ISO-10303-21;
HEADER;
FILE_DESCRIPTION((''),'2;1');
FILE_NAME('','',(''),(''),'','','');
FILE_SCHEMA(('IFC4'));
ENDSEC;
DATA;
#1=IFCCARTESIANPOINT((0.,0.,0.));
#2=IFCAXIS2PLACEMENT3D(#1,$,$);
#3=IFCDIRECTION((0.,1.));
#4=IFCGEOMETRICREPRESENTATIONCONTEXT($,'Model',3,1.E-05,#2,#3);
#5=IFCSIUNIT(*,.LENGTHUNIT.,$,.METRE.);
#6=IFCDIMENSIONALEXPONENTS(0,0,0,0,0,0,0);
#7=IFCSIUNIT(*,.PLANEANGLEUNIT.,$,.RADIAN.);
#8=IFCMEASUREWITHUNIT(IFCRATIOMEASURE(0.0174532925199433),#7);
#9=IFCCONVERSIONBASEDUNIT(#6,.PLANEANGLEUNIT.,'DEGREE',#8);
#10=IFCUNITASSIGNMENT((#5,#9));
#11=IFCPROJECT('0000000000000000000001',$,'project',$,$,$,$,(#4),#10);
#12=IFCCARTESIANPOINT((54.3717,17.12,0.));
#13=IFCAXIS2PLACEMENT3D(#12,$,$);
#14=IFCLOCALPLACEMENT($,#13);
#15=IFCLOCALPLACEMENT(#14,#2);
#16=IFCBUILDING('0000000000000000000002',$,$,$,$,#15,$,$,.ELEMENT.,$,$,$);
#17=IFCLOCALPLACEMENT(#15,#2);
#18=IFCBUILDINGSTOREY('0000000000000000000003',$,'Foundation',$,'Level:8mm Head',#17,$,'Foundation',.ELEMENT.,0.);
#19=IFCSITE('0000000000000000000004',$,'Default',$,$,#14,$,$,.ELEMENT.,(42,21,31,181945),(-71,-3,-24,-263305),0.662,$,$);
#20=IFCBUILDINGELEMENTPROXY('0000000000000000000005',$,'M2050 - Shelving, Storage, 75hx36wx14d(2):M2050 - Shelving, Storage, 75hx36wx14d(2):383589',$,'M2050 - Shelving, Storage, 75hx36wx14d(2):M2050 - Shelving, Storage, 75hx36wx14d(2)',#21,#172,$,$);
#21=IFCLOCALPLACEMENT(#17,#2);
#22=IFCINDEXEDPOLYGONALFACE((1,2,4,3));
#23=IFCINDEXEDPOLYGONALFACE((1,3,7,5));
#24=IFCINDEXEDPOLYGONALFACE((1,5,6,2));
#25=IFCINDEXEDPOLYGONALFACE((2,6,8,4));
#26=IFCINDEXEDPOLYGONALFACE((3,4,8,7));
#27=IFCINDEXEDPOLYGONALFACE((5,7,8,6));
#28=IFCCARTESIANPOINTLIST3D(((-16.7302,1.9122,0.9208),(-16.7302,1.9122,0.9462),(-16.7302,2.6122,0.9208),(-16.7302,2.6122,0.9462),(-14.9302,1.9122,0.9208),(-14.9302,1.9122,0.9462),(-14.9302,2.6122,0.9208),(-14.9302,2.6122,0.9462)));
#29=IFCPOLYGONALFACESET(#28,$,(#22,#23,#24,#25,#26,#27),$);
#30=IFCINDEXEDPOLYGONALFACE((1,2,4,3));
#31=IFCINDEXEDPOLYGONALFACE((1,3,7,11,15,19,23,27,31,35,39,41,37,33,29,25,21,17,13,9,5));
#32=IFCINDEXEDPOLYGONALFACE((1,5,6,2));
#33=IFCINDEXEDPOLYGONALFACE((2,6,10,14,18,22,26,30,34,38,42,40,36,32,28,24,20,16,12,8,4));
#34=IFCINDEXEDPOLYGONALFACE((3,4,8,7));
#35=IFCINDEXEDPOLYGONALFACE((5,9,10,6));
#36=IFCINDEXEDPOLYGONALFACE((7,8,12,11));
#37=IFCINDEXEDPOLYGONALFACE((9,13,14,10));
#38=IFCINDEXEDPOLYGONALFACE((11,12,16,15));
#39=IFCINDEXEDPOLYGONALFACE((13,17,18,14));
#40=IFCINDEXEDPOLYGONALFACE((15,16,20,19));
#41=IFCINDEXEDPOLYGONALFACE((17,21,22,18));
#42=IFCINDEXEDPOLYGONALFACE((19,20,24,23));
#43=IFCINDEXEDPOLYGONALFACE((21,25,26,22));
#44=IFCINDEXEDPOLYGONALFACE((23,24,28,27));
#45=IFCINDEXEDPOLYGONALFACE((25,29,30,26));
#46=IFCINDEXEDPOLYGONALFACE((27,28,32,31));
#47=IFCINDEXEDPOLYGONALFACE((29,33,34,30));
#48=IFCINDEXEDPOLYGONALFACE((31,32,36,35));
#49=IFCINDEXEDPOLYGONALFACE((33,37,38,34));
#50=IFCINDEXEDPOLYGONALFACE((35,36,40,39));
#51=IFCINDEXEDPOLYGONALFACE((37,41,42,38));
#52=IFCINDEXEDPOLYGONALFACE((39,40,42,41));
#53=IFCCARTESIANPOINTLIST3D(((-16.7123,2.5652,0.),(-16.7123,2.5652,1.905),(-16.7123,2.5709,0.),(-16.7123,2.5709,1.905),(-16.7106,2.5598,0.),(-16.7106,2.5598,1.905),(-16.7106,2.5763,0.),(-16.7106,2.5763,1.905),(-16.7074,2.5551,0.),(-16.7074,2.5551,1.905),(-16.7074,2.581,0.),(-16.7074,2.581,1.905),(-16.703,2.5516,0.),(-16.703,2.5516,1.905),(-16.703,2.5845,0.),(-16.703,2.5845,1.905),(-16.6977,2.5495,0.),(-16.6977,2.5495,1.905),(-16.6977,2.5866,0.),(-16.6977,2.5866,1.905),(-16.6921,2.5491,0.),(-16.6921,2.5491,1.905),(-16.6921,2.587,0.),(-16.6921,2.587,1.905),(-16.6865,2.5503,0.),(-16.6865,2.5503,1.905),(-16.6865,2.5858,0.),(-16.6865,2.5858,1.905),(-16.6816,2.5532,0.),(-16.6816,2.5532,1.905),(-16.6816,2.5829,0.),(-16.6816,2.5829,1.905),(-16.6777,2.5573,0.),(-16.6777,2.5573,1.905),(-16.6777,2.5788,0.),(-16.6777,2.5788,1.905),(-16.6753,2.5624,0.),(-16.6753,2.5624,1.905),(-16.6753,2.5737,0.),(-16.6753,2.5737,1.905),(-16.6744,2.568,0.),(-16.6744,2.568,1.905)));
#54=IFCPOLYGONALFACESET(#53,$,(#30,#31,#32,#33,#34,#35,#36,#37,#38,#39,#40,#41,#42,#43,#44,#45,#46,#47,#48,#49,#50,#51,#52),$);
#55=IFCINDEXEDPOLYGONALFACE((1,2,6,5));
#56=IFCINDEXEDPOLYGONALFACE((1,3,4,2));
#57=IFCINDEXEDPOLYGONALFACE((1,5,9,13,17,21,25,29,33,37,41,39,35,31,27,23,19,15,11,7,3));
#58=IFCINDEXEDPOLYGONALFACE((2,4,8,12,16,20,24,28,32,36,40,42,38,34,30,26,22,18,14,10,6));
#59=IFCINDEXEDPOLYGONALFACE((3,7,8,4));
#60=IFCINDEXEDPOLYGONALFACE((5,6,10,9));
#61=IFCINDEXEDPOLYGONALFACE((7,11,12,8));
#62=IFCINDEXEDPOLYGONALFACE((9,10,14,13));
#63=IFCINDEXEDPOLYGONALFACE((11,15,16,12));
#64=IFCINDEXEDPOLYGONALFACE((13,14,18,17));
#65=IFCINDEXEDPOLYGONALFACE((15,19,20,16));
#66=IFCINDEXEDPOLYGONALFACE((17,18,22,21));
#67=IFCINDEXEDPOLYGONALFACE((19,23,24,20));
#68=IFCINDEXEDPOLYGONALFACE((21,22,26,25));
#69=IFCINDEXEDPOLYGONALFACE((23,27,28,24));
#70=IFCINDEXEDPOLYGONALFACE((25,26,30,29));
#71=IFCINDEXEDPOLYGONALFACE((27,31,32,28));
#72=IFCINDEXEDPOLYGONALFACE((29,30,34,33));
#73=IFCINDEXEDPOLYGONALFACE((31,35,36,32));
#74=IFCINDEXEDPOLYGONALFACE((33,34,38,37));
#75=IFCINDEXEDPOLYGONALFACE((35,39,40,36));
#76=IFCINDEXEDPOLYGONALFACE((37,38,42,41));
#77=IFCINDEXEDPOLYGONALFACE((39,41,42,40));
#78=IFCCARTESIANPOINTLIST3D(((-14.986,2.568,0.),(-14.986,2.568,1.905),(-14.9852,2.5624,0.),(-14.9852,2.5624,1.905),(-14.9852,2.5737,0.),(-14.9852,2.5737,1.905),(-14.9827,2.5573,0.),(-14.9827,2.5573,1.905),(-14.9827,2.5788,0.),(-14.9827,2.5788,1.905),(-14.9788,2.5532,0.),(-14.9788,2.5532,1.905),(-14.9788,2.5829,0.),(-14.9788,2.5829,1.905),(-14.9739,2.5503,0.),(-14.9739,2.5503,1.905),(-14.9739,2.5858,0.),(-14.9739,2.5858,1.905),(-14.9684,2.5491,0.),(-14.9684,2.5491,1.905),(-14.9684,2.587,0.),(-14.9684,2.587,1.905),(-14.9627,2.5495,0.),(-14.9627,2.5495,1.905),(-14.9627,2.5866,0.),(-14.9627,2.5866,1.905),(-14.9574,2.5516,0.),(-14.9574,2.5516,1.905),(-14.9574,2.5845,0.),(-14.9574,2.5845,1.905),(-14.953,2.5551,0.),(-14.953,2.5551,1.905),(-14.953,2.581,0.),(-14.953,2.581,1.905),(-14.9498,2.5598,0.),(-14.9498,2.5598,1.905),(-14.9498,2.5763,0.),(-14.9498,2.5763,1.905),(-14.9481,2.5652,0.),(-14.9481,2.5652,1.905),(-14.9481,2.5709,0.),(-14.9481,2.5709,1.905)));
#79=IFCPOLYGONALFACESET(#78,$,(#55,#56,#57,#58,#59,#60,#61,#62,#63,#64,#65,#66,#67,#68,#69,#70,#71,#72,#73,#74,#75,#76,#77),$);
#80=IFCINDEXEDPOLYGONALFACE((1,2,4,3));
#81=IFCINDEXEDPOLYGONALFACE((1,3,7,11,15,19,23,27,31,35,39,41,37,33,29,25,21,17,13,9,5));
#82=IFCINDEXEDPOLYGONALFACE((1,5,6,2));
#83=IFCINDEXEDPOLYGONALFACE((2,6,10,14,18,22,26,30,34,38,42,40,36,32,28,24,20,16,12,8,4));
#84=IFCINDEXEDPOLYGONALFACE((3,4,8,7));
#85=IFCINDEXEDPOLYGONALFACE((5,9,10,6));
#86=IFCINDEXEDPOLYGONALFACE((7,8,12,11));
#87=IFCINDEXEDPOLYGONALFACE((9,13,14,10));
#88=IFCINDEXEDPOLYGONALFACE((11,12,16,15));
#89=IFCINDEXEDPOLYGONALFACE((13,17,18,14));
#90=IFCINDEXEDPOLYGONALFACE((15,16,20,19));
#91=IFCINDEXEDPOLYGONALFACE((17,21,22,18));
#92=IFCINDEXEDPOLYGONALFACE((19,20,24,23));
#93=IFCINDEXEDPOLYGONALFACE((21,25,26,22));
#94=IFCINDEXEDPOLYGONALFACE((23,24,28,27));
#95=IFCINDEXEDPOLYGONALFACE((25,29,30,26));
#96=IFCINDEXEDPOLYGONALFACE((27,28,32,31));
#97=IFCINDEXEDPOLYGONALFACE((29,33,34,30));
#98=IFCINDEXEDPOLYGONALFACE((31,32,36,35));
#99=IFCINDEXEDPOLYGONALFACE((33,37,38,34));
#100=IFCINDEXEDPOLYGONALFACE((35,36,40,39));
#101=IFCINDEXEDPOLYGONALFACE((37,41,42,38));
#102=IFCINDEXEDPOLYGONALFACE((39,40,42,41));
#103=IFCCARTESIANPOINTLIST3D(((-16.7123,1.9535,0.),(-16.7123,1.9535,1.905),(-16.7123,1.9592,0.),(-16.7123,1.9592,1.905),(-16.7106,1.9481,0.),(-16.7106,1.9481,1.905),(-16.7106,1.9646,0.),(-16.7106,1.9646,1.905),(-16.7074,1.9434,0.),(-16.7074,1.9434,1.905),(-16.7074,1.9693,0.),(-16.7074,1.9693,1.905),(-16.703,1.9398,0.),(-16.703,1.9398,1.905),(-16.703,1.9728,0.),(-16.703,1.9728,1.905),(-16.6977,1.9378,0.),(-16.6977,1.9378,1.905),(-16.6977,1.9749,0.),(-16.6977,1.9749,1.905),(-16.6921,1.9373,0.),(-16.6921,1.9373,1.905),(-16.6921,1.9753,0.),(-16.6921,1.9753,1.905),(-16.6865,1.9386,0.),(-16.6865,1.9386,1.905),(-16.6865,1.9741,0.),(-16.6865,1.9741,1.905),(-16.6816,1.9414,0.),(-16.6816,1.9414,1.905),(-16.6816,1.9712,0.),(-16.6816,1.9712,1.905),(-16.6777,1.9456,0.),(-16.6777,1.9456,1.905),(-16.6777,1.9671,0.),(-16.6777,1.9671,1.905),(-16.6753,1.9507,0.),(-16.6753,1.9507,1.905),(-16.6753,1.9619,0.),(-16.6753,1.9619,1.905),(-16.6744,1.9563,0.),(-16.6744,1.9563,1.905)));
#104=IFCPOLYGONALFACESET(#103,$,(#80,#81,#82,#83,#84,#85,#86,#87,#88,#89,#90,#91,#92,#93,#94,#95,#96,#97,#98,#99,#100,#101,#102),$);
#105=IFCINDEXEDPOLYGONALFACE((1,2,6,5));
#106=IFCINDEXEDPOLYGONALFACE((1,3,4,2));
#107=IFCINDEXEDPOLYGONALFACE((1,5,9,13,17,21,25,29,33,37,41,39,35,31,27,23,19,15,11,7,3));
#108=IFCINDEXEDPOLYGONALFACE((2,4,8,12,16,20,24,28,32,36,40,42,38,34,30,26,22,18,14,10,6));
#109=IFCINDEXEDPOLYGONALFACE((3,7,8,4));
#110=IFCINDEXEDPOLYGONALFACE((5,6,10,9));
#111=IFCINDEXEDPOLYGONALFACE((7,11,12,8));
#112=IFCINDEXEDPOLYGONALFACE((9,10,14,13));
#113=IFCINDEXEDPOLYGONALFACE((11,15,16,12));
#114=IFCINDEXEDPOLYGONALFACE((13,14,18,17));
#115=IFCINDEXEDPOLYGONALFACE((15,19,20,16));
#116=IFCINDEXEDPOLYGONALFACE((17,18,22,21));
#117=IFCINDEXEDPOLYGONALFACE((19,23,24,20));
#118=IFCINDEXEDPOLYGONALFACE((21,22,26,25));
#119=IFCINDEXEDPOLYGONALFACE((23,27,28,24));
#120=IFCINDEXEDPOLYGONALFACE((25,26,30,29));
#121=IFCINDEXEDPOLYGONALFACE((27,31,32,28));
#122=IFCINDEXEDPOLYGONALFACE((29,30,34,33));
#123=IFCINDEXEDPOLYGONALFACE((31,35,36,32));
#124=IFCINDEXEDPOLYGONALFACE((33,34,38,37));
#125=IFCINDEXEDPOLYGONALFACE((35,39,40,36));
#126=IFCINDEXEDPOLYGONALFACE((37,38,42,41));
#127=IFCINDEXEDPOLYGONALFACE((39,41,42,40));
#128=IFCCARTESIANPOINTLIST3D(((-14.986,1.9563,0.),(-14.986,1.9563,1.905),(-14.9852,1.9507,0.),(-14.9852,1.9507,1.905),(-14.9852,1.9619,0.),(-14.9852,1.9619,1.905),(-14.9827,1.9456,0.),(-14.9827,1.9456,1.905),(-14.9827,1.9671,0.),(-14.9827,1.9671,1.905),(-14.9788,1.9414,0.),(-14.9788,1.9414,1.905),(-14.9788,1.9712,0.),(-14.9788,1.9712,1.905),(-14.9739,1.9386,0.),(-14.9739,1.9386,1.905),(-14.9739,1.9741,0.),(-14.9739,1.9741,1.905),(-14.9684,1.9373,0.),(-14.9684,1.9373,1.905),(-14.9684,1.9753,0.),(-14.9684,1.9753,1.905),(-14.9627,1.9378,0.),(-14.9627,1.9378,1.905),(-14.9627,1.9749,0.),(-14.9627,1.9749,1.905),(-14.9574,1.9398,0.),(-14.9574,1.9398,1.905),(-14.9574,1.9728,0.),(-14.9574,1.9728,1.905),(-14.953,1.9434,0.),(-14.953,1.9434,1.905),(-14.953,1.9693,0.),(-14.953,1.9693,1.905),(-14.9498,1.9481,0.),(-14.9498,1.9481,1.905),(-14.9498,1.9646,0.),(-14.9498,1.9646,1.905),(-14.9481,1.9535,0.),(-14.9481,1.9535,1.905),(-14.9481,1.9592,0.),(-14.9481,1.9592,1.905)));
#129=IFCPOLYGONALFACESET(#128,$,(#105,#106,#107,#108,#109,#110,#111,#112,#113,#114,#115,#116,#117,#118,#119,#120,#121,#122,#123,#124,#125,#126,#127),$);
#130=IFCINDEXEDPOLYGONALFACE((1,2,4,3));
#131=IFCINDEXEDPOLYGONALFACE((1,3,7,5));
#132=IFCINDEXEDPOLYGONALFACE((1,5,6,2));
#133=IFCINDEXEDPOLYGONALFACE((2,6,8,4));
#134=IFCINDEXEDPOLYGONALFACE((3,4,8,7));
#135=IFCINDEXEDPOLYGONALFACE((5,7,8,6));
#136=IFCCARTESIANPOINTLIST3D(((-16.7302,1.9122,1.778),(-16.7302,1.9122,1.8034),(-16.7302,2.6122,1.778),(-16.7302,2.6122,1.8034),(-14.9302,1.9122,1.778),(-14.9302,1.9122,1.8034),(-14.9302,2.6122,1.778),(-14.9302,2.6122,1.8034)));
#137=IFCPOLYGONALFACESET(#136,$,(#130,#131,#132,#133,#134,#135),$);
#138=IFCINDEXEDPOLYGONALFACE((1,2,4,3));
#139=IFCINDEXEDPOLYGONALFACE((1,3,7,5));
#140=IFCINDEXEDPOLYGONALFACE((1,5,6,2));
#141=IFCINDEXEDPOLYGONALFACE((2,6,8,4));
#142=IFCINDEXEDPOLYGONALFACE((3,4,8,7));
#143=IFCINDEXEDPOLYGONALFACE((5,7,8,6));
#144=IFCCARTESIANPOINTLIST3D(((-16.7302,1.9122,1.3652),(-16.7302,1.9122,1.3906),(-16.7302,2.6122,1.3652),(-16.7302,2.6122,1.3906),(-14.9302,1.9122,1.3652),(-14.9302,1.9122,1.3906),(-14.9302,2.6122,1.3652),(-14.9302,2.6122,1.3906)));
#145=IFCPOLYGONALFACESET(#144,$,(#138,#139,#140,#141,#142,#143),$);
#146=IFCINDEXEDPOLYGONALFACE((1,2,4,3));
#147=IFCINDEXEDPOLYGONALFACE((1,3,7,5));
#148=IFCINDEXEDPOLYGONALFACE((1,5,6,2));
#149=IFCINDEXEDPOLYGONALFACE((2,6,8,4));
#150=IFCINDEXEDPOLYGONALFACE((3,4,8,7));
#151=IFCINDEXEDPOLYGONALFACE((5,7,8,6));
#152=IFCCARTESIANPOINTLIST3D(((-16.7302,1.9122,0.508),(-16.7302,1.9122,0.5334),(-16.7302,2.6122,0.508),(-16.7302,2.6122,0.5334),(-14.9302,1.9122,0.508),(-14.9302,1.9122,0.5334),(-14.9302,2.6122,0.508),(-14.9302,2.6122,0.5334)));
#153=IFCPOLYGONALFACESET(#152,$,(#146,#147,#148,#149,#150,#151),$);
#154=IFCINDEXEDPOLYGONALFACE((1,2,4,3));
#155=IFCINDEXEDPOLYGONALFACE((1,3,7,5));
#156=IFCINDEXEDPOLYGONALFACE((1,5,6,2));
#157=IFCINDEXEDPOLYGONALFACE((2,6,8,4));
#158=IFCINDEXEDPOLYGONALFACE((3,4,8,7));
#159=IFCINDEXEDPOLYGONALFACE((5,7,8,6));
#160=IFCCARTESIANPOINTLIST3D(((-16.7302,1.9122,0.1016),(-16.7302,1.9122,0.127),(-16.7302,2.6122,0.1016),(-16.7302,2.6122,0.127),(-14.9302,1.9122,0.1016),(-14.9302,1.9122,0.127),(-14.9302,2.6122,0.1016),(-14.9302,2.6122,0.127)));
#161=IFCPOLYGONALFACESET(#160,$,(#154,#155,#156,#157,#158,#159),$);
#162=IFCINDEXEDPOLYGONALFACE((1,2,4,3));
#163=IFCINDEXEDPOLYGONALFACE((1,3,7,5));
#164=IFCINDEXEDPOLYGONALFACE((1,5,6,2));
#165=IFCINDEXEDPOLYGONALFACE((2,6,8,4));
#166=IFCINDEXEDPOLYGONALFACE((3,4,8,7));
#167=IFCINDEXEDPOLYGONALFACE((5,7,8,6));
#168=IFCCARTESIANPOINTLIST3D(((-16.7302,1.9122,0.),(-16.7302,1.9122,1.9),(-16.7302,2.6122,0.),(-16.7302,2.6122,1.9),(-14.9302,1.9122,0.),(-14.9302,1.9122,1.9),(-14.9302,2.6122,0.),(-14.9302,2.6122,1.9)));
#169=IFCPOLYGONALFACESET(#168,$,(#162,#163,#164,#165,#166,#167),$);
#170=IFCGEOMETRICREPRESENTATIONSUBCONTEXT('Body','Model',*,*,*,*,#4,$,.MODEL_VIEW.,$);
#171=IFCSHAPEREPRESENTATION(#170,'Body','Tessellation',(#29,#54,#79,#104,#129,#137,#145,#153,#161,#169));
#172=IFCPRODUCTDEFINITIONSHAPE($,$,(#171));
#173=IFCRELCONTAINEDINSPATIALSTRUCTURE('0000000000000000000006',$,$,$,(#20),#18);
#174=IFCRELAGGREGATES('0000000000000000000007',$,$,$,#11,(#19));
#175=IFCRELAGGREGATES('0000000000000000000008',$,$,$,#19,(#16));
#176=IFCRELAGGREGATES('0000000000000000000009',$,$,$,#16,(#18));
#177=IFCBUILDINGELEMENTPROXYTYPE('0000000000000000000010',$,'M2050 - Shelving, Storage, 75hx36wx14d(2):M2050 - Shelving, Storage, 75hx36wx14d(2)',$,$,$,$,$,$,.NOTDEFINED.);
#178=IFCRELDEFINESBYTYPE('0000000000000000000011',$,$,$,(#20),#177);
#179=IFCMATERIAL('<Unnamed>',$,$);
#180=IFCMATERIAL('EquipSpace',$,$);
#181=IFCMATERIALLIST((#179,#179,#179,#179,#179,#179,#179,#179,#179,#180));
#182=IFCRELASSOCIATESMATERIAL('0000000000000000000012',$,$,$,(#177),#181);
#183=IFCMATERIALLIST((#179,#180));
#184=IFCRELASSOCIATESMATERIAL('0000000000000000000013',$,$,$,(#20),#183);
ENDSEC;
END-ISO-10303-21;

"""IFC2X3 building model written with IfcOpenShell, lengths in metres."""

from ifc_helpers import new_model, entity, si_unit, converted_unit, direction, frame, frame_2d, origin, origin_2d_with_axis, place, context, subcontext, project, spatial, rectangle, circle, extrude, source, transform, mapped, material, material_list, type_object, type_shapes, element, save


model = new_model("IFC2X3")

# Units and contexts
model_context = context("Model", 3, precision=1e-05, world=origin(), true_north=direction((0.0, 1.0)))
body_context = subcontext(model_context, "Body", "Model", "MODEL_VIEW")
ifc_project = project(units=[si_unit("LENGTHUNIT", "METRE"), converted_unit("PLANEANGLEUNIT", "DEGREE", entity("IfcRatioMeasure", 0.0174532925199433), si_unit("PLANEANGLEUNIT", "RADIAN"), dimensions=[0, 0, 0, 0, 0, 0, 0])], contexts=[model_context])

# Site, building, storey
site_placement = place(None, frame((54.3717, 17.12, 0.0)))
site = spatial("IfcSite", under=ifc_project, at=site_placement, Name="Default", CompositionType="ELEMENT", RefLatitude=(42, 21, 31, 181945), RefLongitude=(-71, -3, -24, -263305), RefElevation=0.662)
building_placement = place(site_placement, origin())
building = spatial("IfcBuilding", under=site, at=building_placement, CompositionType="ELEMENT")
storey_placement = place(building_placement, origin())
storey = spatial("IfcBuildingStorey", under=building, at=storey_placement, Name="Foundation", ObjectType="Level:8mm Head", LongName="Foundation", CompositionType="ELEMENT", Elevation=0.0)

# Building element proxy
ifc_material_1 = material(Name="<Unnamed>")
ifc_material_2 = material(Name="EquipSpace")
ifc_material_list_1 = material_list([ifc_material_1, ifc_material_1, ifc_material_1, ifc_material_1, ifc_material_1, ifc_material_1, ifc_material_1, ifc_material_1, ifc_material_1, ifc_material_2])
building_element_proxy_type = type_object("IfcBuildingElementProxyType", Name="M2050 - Shelving, Storage, 75hx36wx14d(2):M2050 - Shelving, Storage, 75hx36wx14d(2)", PredefinedType="NOTDEFINED", material=ifc_material_list_1)
shared_shape = source(origin(), body_context, "Body", "SweptSolid", [
    extrude(rectangle(XDim=1.8, YDim=0.7, at=origin_2d_with_axis()), frame((0.0, 0.0, 0.9207), z_axis=(0.0, 0.0, 1.0), x_axis=(-1.0, 0.0, 0.0)), (0.0, 0.0, 1.0), 0.0254),
    extrude(circle(Radius=0.0191, at=origin_2d_with_axis()), frame((0.8633, -0.3059, 0.0), z_axis=(0.0, 0.0, 1.0), x_axis=(-1.0, 0.0, 0.0)), (0.0, 0.0, 1.0), 1.905),
    extrude(circle(Radius=0.0191, at=origin_2d_with_axis()), frame((-0.8633, -0.3059, 0.0)), (0.0, 0.0, 1.0), 1.905),
    extrude(circle(Radius=0.0191, at=origin_2d_with_axis()), frame((0.8633, 0.3059, 0.0), z_axis=(0.0, 0.0, 1.0), x_axis=(-1.0, 0.0, 0.0)), (0.0, 0.0, 1.0), 1.905),
    extrude(circle(Radius=0.0191, at=origin_2d_with_axis()), frame((-0.8633, 0.3059, 0.0)), (0.0, 0.0, 1.0), 1.905),
    extrude(rectangle(XDim=1.8, YDim=0.7, at=origin_2d_with_axis()), frame((0.0, 0.0, 1.778), z_axis=(0.0, 0.0, 1.0), x_axis=(-1.0, 0.0, 0.0)), (0.0, 0.0, 1.0), 0.0254),
    extrude(rectangle(XDim=1.8, YDim=0.7, at=origin_2d_with_axis()), frame((0.0, 0.0, 1.3653), z_axis=(0.0, 0.0, 1.0), x_axis=(-1.0, 0.0, 0.0)), (0.0, 0.0, 1.0), 0.0254),
    extrude(rectangle(XDim=1.8, YDim=0.7, at=origin_2d_with_axis()), frame((0.0, 0.0, 0.508), z_axis=(0.0, 0.0, 1.0), x_axis=(-1.0, 0.0, 0.0)), (0.0, 0.0, 1.0), 0.0254),
    extrude(rectangle(XDim=1.8, YDim=0.7, at=origin_2d_with_axis()), frame((0.0, 0.0, 0.1016), z_axis=(0.0, 0.0, 1.0), x_axis=(-1.0, 0.0, 0.0)), (0.0, 0.0, 1.0), 0.0254),
    extrude(rectangle(XDim=0.7, YDim=1.8, at=frame_2d((0.0, 0.18), x_axis=(1.0, 0.0))), frame((-0.18, 0.0, 0.0), z_axis=(0.0, 0.0, 1.0), x_axis=(0.0, -1.0, 0.0)), (0.0, 0.0, 1.0), 1.9),
])
type_shapes(building_element_proxy_type, [shared_shape])
ifc_material_list_2 = material_list([ifc_material_1, ifc_material_2])
proxy_1_placement = place(storey_placement, frame((-15.8302, 2.2622, 0.0), z_axis=(0.0, 0.0, 1.0), x_axis=(-1.0, 0.0, 0.0)))
element("IfcBuildingElementProxy", 1, at=proxy_1_placement, inside=storey, type_object=building_element_proxy_type, material=ifc_material_list_2, Name="M2050 - Shelving, Storage, 75hx36wx14d(2):M2050 - Shelving, Storage, 75hx36wx14d(2):383589", ObjectType="M2050 - Shelving, Storage, 75hx36wx14d(2):M2050 - Shelving, Storage, 75hx36wx14d(2)", context=body_context, shape_type="MappedRepresentation", body=[
    mapped(shared_shape, transform((0.0, 0.0, 0.0), scale=1.0)),
])

save(model, "model.ifc")
